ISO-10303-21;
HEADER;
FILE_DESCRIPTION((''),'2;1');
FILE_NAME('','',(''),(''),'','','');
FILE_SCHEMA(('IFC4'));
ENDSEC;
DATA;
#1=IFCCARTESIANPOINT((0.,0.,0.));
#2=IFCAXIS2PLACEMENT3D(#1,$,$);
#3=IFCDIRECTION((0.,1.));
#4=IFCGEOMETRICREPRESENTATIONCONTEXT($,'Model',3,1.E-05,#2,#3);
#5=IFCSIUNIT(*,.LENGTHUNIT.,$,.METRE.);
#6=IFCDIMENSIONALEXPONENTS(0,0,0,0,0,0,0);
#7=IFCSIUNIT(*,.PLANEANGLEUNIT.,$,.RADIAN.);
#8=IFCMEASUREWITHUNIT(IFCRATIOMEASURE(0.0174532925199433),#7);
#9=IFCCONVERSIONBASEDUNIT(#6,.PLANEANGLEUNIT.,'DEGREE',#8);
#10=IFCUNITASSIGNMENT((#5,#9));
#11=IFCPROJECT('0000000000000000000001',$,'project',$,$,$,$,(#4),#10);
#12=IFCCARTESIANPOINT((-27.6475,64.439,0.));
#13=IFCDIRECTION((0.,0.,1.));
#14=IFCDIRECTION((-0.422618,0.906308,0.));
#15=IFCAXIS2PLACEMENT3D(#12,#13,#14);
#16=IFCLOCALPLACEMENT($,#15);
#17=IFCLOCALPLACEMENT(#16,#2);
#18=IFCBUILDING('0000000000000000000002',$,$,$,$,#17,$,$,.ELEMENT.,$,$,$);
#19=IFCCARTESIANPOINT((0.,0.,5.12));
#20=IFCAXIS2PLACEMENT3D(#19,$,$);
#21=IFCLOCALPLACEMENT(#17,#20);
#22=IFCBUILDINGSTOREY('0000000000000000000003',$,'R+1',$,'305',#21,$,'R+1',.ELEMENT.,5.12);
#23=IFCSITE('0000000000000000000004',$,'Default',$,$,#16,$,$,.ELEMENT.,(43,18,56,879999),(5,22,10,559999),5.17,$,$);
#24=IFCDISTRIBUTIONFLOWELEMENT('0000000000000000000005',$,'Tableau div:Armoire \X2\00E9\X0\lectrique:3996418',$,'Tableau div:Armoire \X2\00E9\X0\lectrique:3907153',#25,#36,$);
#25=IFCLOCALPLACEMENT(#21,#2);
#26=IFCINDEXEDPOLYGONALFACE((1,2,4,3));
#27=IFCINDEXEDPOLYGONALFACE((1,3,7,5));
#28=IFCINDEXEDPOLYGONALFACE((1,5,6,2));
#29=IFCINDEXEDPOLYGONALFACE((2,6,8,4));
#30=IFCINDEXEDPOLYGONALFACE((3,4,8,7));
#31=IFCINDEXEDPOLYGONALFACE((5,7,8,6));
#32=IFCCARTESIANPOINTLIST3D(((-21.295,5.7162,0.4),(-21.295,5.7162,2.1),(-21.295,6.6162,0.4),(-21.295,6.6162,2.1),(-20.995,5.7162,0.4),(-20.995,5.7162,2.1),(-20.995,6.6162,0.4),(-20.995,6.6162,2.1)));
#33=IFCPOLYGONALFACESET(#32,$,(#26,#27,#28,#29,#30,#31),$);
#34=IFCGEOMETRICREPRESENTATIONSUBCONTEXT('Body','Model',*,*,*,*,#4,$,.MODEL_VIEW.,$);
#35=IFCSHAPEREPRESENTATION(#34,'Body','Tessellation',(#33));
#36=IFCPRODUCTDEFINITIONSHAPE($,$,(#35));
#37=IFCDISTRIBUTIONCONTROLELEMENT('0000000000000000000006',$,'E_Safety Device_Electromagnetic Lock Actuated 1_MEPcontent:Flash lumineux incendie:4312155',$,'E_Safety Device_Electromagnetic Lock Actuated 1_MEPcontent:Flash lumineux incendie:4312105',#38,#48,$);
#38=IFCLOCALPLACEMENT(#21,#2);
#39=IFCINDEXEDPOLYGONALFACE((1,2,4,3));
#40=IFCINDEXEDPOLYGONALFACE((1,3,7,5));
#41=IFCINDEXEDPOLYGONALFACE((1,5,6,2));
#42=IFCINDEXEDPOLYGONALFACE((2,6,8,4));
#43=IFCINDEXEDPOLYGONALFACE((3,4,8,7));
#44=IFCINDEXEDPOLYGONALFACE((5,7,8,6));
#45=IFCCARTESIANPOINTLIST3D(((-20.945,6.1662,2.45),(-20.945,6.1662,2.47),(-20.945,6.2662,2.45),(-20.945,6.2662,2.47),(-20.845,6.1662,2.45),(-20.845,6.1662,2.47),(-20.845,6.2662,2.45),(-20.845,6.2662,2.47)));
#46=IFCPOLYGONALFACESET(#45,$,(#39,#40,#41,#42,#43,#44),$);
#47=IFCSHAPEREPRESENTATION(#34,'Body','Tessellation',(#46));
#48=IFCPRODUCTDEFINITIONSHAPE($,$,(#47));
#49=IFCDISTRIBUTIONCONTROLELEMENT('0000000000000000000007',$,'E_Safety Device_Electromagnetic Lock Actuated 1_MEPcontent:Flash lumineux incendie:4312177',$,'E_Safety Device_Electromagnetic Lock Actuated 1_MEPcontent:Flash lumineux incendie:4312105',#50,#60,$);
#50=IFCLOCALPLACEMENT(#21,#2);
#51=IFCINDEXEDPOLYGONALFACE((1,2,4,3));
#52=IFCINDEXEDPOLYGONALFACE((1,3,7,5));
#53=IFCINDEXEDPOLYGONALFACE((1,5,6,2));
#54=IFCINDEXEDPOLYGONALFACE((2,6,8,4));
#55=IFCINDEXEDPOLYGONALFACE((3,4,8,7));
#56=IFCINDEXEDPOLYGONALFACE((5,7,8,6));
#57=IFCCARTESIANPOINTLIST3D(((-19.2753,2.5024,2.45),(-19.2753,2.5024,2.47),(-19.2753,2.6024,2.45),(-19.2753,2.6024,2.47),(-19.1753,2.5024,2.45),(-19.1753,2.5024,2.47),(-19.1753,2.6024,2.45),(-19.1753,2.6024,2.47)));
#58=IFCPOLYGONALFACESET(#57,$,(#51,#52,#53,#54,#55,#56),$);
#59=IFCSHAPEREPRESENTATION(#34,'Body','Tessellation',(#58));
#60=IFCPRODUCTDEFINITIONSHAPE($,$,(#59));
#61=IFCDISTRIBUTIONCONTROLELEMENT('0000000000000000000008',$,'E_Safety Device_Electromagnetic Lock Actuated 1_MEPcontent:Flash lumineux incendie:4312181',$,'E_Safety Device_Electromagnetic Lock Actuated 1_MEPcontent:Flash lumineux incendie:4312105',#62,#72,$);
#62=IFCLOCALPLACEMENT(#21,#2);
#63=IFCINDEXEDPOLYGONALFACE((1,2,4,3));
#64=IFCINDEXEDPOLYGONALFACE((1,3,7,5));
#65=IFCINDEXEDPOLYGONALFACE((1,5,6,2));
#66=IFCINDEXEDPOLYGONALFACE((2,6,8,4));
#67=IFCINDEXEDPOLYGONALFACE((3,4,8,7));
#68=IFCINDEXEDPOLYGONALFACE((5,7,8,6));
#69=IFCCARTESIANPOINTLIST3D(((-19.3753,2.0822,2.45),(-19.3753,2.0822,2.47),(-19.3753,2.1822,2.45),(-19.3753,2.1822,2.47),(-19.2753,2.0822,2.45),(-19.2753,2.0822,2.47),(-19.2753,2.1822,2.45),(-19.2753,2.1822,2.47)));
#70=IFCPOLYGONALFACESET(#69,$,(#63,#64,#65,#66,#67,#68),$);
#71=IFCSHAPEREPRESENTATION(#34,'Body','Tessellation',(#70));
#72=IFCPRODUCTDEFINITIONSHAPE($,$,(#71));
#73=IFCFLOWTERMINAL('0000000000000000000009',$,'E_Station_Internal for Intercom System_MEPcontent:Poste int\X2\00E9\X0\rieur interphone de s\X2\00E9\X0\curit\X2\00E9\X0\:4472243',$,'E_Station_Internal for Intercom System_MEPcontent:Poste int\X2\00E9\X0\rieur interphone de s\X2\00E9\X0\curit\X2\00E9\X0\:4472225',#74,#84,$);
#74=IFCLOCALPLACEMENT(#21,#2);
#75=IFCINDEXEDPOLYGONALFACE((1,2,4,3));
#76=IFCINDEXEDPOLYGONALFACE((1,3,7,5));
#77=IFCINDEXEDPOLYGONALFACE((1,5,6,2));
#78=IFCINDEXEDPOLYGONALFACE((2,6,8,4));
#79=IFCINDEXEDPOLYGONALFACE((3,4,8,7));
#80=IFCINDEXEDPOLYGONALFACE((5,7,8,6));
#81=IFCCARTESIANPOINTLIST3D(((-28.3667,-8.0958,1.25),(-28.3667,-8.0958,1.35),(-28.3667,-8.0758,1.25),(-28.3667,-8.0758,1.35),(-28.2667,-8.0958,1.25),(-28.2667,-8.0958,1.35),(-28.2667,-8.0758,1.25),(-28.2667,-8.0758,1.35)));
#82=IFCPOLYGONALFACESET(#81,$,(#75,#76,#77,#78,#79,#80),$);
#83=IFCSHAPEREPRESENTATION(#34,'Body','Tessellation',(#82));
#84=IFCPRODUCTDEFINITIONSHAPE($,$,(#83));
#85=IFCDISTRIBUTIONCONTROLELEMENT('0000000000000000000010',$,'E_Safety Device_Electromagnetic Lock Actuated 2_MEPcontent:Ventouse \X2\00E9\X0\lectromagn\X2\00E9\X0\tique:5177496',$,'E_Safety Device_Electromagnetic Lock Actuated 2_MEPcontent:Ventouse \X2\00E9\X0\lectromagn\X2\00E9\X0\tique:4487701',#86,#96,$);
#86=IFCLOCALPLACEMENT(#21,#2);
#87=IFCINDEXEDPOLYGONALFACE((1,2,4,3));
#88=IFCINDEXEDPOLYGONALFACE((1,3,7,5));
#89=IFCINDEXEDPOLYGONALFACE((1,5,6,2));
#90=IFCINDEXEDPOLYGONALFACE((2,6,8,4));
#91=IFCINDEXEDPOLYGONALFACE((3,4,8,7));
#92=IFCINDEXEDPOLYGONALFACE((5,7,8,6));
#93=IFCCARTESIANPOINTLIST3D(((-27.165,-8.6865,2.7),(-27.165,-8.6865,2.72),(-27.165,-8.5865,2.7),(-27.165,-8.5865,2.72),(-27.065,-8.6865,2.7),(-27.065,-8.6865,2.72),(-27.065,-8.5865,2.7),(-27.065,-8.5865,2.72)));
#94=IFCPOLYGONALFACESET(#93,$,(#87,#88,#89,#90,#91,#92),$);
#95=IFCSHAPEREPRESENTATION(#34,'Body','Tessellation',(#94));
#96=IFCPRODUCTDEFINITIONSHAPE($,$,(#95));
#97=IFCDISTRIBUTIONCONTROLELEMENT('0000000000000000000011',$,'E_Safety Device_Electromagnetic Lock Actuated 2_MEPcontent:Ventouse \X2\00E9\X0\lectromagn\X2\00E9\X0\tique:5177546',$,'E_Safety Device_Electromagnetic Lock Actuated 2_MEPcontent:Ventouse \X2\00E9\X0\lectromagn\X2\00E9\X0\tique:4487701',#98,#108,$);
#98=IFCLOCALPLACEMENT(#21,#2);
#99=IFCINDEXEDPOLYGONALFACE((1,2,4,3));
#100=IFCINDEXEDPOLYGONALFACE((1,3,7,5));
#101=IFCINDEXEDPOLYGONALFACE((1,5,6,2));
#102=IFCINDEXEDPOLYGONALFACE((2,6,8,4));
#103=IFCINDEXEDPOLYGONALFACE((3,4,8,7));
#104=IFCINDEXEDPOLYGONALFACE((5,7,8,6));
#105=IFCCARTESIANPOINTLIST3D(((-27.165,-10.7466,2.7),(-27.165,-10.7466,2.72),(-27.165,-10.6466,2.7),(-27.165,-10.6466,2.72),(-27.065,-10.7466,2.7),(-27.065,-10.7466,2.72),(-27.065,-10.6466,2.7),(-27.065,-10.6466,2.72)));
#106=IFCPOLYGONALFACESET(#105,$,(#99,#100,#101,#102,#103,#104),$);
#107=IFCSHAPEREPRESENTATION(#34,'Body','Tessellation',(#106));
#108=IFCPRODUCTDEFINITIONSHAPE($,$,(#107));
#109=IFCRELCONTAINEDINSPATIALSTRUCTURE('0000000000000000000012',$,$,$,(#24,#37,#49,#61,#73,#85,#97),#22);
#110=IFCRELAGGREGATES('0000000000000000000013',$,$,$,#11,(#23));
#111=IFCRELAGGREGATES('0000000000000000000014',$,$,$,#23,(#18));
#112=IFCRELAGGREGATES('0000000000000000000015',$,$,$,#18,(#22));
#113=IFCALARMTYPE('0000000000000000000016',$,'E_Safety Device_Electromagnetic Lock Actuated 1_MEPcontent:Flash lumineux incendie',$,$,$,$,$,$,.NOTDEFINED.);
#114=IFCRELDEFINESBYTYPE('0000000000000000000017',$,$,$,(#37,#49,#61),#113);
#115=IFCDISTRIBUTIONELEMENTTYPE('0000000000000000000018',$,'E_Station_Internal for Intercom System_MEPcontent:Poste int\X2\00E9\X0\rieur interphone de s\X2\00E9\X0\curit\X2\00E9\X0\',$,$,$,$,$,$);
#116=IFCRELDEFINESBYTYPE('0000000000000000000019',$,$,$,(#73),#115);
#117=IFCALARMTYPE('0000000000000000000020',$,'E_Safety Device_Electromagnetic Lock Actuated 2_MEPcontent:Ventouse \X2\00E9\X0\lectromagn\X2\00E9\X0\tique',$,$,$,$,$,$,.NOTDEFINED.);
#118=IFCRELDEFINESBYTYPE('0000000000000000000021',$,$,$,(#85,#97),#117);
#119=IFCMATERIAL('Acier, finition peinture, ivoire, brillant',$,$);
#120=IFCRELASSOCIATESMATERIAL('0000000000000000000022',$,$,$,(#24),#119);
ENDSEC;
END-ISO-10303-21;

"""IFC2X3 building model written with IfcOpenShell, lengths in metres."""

from ifc_helpers import new_model, entity, si_unit, converted_unit, direction, frame, frame_2d, origin, origin_2d_with_axis, place, context, subcontext, project, spatial, rectangle, extrude, source, transform, mapped, material, type_object, type_shapes, element, save


model = new_model("IFC2X3")

# Units and contexts
model_context = context("Model", 3, precision=1e-05, world=origin(), true_north=direction((0.0, 1.0)))
body_context = subcontext(model_context, "Body", "Model", "MODEL_VIEW")
ifc_project = project(units=[si_unit("LENGTHUNIT", "METRE"), converted_unit("PLANEANGLEUNIT", "DEGREE", entity("IfcRatioMeasure", 0.0174532925199433), si_unit("PLANEANGLEUNIT", "RADIAN"), dimensions=[0, 0, 0, 0, 0, 0, 0])], contexts=[model_context])

# Site, building, storey
site_placement = place(None, frame((-27.6475, 64.439, 0.0), z_axis=(0.0, 0.0, 1.0), x_axis=(-0.422618, 0.906308, 0.0)))
site = spatial("IfcSite", under=ifc_project, at=site_placement, Name="Default", CompositionType="ELEMENT", RefLatitude=(43, 18, 56, 879999), RefLongitude=(5, 22, 10, 559999), RefElevation=5.17)
building_placement = place(site_placement, origin())
building = spatial("IfcBuilding", under=site, at=building_placement, CompositionType="ELEMENT")
storey_placement = place(building_placement, frame((0.0, 0.0, 5.12)))
storey = spatial("IfcBuildingStorey", under=building, at=storey_placement, Name="R+1", ObjectType="305", LongName="R+1", CompositionType="ELEMENT", Elevation=5.12)

# Distribution flow element
ifc_material_1 = material(Name="Acier, finition peinture, ivoire, brillant")
shared_shape_1 = source(origin(), body_context, "Body", "SweptSolid", [
    extrude(rectangle(XDim=0.9, YDim=0.3, at=origin_2d_with_axis()), frame((0.0, -0.45, 0.0), z_axis=(0.0, 0.0, 1.0), x_axis=(0.0, 1.0, 0.0)), (0.0, 0.0, 1.0), 1.7),
])
distribution_flow_element_placement = place(storey_placement, frame((-21.145, 5.7162, 0.4), z_axis=(0.0, 0.0, 1.0), x_axis=(-1.0, 0.0, 0.0)))
element("IfcDistributionFlowElement", 1, at=distribution_flow_element_placement, inside=storey, material=ifc_material_1, Name="Tableau div:Armoire électrique:3996418", ObjectType="Tableau div:Armoire électrique:3907153", context=body_context, shape_type="MappedRepresentation", body=[
    mapped(shared_shape_1, transform((0.0, 0.0, 0.0), scale=1.0)),
])

# Distribution control elements
alarm_type_1 = type_object("IfcAlarmType", Name="E_Safety Device_Electromagnetic Lock Actuated 1_MEPcontent:Flash lumineux incendie", PredefinedType="NOTDEFINED")
shared_shape_2 = source(origin(), body_context, "Body", "SweptSolid", [
    extrude(rectangle(XDim=0.1, YDim=0.1, at=origin_2d_with_axis()), frame((0.0, 0.0, 0.0), z_axis=(0.0, 0.0, 1.0), x_axis=(0.0, -1.0, 0.0)), (0.0, 0.0, 1.0), 0.02),
])
type_shapes(alarm_type_1, [shared_shape_2])
for number, where, z_axis, x_axis, name in (
    (2, (-20.895, 6.2162, 2.45), (0.0, 0.0, 1.0), (0.0, -1.0, 0.0), "E_Safety Device_Electromagnetic Lock Actuated 1_MEPcontent:Flash lumineux incendie:4312155"),
    (3, (-19.2253, 2.5524, 2.45), (0.0, 0.0, 1.0), (0.0, -1.0, 0.0), "E_Safety Device_Electromagnetic Lock Actuated 1_MEPcontent:Flash lumineux incendie:4312177"),
    (4, (-19.3253, 2.1322, 2.45), (0.0, 0.0, 1.0), (0.0, -1.0, 0.0), "E_Safety Device_Electromagnetic Lock Actuated 1_MEPcontent:Flash lumineux incendie:4312181"),
):
    element("IfcDistributionControlElement", number, at=place(storey_placement, frame(where, z_axis=z_axis, x_axis=x_axis)), inside=storey, type_object=alarm_type_1, Name=name, ObjectType="E_Safety Device_Electromagnetic Lock Actuated 1_MEPcontent:Flash lumineux incendie:4312105", context=body_context, shape_type="MappedRepresentation", body=[
        mapped(shared_shape_2, transform((0.0, 0.0, 0.0), scale=1.0)),
    ])

# Flow terminal
distribution_element_type_1 = type_object("IfcDistributionElementType", Name="E_Station_Internal for Intercom System_MEPcontent:Poste intérieur interphone de sécurité")
shared_shape_3 = source(origin(), body_context, "Body", "SweptSolid", [
    extrude(rectangle(XDim=0.02, YDim=0.1, at=frame_2d((0.0, 0.0), x_axis=(1.0, 0.0))), frame((0.0, -0.01, -0.05), z_axis=(0.0, 0.0, 1.0), x_axis=(0.0, 1.0, 0.0)), (0.0, 0.0, 1.0), 0.1),
])
type_shapes(distribution_element_type_1, [shared_shape_3])
flow_terminal_1_placement = place(storey_placement, frame((-28.3167, -8.0958, 1.3), z_axis=(0.0, 0.0, 1.0), x_axis=(-1.0, 0.0, 0.0)))
element("IfcFlowTerminal", 5, at=flow_terminal_1_placement, inside=storey, type_object=distribution_element_type_1, Name="E_Station_Internal for Intercom System_MEPcontent:Poste intérieur interphone de sécurité:4472243", ObjectType="E_Station_Internal for Intercom System_MEPcontent:Poste intérieur interphone de sécurité:4472225", context=body_context, shape_type="MappedRepresentation", body=[
    mapped(shared_shape_3, transform((0.0, 0.0, 0.0), scale=1.0)),
])

# Distribution control elements
alarm_type_2 = type_object("IfcAlarmType", Name="E_Safety Device_Electromagnetic Lock Actuated 2_MEPcontent:Ventouse électromagnétique", PredefinedType="NOTDEFINED")
shared_shape_4 = source(origin(), body_context, "Body", "SweptSolid", [
    extrude(rectangle(XDim=0.1, YDim=0.1, at=origin_2d_with_axis()), frame((0.0, 0.0, 0.0), z_axis=(0.0, 0.0, 1.0), x_axis=(0.0, -1.0, 0.0)), (0.0, 0.0, 1.0), 0.02),
])
type_shapes(alarm_type_2, [shared_shape_4])
for number, where, z_axis, x_axis, name in (
    (6, (-27.115, -8.6365, 2.7), (0.0, 0.0, 1.0), (0.0, -1.0, 0.0), "E_Safety Device_Electromagnetic Lock Actuated 2_MEPcontent:Ventouse électromagnétique:5177496"),
    (7, (-27.115, -10.6966, 2.7), (0.0, 0.0, 1.0), (0.0, -1.0, 0.0), "E_Safety Device_Electromagnetic Lock Actuated 2_MEPcontent:Ventouse électromagnétique:5177546"),
):
    element("IfcDistributionControlElement", number, at=place(storey_placement, frame(where, z_axis=z_axis, x_axis=x_axis)), inside=storey, type_object=alarm_type_2, Name=name, ObjectType="E_Safety Device_Electromagnetic Lock Actuated 2_MEPcontent:Ventouse électromagnétique:4487701", context=body_context, shape_type="MappedRepresentation", body=[
        mapped(shared_shape_4, transform((0.0, 0.0, 0.0), scale=1.0)),
    ])

save(model, "model.ifc")
